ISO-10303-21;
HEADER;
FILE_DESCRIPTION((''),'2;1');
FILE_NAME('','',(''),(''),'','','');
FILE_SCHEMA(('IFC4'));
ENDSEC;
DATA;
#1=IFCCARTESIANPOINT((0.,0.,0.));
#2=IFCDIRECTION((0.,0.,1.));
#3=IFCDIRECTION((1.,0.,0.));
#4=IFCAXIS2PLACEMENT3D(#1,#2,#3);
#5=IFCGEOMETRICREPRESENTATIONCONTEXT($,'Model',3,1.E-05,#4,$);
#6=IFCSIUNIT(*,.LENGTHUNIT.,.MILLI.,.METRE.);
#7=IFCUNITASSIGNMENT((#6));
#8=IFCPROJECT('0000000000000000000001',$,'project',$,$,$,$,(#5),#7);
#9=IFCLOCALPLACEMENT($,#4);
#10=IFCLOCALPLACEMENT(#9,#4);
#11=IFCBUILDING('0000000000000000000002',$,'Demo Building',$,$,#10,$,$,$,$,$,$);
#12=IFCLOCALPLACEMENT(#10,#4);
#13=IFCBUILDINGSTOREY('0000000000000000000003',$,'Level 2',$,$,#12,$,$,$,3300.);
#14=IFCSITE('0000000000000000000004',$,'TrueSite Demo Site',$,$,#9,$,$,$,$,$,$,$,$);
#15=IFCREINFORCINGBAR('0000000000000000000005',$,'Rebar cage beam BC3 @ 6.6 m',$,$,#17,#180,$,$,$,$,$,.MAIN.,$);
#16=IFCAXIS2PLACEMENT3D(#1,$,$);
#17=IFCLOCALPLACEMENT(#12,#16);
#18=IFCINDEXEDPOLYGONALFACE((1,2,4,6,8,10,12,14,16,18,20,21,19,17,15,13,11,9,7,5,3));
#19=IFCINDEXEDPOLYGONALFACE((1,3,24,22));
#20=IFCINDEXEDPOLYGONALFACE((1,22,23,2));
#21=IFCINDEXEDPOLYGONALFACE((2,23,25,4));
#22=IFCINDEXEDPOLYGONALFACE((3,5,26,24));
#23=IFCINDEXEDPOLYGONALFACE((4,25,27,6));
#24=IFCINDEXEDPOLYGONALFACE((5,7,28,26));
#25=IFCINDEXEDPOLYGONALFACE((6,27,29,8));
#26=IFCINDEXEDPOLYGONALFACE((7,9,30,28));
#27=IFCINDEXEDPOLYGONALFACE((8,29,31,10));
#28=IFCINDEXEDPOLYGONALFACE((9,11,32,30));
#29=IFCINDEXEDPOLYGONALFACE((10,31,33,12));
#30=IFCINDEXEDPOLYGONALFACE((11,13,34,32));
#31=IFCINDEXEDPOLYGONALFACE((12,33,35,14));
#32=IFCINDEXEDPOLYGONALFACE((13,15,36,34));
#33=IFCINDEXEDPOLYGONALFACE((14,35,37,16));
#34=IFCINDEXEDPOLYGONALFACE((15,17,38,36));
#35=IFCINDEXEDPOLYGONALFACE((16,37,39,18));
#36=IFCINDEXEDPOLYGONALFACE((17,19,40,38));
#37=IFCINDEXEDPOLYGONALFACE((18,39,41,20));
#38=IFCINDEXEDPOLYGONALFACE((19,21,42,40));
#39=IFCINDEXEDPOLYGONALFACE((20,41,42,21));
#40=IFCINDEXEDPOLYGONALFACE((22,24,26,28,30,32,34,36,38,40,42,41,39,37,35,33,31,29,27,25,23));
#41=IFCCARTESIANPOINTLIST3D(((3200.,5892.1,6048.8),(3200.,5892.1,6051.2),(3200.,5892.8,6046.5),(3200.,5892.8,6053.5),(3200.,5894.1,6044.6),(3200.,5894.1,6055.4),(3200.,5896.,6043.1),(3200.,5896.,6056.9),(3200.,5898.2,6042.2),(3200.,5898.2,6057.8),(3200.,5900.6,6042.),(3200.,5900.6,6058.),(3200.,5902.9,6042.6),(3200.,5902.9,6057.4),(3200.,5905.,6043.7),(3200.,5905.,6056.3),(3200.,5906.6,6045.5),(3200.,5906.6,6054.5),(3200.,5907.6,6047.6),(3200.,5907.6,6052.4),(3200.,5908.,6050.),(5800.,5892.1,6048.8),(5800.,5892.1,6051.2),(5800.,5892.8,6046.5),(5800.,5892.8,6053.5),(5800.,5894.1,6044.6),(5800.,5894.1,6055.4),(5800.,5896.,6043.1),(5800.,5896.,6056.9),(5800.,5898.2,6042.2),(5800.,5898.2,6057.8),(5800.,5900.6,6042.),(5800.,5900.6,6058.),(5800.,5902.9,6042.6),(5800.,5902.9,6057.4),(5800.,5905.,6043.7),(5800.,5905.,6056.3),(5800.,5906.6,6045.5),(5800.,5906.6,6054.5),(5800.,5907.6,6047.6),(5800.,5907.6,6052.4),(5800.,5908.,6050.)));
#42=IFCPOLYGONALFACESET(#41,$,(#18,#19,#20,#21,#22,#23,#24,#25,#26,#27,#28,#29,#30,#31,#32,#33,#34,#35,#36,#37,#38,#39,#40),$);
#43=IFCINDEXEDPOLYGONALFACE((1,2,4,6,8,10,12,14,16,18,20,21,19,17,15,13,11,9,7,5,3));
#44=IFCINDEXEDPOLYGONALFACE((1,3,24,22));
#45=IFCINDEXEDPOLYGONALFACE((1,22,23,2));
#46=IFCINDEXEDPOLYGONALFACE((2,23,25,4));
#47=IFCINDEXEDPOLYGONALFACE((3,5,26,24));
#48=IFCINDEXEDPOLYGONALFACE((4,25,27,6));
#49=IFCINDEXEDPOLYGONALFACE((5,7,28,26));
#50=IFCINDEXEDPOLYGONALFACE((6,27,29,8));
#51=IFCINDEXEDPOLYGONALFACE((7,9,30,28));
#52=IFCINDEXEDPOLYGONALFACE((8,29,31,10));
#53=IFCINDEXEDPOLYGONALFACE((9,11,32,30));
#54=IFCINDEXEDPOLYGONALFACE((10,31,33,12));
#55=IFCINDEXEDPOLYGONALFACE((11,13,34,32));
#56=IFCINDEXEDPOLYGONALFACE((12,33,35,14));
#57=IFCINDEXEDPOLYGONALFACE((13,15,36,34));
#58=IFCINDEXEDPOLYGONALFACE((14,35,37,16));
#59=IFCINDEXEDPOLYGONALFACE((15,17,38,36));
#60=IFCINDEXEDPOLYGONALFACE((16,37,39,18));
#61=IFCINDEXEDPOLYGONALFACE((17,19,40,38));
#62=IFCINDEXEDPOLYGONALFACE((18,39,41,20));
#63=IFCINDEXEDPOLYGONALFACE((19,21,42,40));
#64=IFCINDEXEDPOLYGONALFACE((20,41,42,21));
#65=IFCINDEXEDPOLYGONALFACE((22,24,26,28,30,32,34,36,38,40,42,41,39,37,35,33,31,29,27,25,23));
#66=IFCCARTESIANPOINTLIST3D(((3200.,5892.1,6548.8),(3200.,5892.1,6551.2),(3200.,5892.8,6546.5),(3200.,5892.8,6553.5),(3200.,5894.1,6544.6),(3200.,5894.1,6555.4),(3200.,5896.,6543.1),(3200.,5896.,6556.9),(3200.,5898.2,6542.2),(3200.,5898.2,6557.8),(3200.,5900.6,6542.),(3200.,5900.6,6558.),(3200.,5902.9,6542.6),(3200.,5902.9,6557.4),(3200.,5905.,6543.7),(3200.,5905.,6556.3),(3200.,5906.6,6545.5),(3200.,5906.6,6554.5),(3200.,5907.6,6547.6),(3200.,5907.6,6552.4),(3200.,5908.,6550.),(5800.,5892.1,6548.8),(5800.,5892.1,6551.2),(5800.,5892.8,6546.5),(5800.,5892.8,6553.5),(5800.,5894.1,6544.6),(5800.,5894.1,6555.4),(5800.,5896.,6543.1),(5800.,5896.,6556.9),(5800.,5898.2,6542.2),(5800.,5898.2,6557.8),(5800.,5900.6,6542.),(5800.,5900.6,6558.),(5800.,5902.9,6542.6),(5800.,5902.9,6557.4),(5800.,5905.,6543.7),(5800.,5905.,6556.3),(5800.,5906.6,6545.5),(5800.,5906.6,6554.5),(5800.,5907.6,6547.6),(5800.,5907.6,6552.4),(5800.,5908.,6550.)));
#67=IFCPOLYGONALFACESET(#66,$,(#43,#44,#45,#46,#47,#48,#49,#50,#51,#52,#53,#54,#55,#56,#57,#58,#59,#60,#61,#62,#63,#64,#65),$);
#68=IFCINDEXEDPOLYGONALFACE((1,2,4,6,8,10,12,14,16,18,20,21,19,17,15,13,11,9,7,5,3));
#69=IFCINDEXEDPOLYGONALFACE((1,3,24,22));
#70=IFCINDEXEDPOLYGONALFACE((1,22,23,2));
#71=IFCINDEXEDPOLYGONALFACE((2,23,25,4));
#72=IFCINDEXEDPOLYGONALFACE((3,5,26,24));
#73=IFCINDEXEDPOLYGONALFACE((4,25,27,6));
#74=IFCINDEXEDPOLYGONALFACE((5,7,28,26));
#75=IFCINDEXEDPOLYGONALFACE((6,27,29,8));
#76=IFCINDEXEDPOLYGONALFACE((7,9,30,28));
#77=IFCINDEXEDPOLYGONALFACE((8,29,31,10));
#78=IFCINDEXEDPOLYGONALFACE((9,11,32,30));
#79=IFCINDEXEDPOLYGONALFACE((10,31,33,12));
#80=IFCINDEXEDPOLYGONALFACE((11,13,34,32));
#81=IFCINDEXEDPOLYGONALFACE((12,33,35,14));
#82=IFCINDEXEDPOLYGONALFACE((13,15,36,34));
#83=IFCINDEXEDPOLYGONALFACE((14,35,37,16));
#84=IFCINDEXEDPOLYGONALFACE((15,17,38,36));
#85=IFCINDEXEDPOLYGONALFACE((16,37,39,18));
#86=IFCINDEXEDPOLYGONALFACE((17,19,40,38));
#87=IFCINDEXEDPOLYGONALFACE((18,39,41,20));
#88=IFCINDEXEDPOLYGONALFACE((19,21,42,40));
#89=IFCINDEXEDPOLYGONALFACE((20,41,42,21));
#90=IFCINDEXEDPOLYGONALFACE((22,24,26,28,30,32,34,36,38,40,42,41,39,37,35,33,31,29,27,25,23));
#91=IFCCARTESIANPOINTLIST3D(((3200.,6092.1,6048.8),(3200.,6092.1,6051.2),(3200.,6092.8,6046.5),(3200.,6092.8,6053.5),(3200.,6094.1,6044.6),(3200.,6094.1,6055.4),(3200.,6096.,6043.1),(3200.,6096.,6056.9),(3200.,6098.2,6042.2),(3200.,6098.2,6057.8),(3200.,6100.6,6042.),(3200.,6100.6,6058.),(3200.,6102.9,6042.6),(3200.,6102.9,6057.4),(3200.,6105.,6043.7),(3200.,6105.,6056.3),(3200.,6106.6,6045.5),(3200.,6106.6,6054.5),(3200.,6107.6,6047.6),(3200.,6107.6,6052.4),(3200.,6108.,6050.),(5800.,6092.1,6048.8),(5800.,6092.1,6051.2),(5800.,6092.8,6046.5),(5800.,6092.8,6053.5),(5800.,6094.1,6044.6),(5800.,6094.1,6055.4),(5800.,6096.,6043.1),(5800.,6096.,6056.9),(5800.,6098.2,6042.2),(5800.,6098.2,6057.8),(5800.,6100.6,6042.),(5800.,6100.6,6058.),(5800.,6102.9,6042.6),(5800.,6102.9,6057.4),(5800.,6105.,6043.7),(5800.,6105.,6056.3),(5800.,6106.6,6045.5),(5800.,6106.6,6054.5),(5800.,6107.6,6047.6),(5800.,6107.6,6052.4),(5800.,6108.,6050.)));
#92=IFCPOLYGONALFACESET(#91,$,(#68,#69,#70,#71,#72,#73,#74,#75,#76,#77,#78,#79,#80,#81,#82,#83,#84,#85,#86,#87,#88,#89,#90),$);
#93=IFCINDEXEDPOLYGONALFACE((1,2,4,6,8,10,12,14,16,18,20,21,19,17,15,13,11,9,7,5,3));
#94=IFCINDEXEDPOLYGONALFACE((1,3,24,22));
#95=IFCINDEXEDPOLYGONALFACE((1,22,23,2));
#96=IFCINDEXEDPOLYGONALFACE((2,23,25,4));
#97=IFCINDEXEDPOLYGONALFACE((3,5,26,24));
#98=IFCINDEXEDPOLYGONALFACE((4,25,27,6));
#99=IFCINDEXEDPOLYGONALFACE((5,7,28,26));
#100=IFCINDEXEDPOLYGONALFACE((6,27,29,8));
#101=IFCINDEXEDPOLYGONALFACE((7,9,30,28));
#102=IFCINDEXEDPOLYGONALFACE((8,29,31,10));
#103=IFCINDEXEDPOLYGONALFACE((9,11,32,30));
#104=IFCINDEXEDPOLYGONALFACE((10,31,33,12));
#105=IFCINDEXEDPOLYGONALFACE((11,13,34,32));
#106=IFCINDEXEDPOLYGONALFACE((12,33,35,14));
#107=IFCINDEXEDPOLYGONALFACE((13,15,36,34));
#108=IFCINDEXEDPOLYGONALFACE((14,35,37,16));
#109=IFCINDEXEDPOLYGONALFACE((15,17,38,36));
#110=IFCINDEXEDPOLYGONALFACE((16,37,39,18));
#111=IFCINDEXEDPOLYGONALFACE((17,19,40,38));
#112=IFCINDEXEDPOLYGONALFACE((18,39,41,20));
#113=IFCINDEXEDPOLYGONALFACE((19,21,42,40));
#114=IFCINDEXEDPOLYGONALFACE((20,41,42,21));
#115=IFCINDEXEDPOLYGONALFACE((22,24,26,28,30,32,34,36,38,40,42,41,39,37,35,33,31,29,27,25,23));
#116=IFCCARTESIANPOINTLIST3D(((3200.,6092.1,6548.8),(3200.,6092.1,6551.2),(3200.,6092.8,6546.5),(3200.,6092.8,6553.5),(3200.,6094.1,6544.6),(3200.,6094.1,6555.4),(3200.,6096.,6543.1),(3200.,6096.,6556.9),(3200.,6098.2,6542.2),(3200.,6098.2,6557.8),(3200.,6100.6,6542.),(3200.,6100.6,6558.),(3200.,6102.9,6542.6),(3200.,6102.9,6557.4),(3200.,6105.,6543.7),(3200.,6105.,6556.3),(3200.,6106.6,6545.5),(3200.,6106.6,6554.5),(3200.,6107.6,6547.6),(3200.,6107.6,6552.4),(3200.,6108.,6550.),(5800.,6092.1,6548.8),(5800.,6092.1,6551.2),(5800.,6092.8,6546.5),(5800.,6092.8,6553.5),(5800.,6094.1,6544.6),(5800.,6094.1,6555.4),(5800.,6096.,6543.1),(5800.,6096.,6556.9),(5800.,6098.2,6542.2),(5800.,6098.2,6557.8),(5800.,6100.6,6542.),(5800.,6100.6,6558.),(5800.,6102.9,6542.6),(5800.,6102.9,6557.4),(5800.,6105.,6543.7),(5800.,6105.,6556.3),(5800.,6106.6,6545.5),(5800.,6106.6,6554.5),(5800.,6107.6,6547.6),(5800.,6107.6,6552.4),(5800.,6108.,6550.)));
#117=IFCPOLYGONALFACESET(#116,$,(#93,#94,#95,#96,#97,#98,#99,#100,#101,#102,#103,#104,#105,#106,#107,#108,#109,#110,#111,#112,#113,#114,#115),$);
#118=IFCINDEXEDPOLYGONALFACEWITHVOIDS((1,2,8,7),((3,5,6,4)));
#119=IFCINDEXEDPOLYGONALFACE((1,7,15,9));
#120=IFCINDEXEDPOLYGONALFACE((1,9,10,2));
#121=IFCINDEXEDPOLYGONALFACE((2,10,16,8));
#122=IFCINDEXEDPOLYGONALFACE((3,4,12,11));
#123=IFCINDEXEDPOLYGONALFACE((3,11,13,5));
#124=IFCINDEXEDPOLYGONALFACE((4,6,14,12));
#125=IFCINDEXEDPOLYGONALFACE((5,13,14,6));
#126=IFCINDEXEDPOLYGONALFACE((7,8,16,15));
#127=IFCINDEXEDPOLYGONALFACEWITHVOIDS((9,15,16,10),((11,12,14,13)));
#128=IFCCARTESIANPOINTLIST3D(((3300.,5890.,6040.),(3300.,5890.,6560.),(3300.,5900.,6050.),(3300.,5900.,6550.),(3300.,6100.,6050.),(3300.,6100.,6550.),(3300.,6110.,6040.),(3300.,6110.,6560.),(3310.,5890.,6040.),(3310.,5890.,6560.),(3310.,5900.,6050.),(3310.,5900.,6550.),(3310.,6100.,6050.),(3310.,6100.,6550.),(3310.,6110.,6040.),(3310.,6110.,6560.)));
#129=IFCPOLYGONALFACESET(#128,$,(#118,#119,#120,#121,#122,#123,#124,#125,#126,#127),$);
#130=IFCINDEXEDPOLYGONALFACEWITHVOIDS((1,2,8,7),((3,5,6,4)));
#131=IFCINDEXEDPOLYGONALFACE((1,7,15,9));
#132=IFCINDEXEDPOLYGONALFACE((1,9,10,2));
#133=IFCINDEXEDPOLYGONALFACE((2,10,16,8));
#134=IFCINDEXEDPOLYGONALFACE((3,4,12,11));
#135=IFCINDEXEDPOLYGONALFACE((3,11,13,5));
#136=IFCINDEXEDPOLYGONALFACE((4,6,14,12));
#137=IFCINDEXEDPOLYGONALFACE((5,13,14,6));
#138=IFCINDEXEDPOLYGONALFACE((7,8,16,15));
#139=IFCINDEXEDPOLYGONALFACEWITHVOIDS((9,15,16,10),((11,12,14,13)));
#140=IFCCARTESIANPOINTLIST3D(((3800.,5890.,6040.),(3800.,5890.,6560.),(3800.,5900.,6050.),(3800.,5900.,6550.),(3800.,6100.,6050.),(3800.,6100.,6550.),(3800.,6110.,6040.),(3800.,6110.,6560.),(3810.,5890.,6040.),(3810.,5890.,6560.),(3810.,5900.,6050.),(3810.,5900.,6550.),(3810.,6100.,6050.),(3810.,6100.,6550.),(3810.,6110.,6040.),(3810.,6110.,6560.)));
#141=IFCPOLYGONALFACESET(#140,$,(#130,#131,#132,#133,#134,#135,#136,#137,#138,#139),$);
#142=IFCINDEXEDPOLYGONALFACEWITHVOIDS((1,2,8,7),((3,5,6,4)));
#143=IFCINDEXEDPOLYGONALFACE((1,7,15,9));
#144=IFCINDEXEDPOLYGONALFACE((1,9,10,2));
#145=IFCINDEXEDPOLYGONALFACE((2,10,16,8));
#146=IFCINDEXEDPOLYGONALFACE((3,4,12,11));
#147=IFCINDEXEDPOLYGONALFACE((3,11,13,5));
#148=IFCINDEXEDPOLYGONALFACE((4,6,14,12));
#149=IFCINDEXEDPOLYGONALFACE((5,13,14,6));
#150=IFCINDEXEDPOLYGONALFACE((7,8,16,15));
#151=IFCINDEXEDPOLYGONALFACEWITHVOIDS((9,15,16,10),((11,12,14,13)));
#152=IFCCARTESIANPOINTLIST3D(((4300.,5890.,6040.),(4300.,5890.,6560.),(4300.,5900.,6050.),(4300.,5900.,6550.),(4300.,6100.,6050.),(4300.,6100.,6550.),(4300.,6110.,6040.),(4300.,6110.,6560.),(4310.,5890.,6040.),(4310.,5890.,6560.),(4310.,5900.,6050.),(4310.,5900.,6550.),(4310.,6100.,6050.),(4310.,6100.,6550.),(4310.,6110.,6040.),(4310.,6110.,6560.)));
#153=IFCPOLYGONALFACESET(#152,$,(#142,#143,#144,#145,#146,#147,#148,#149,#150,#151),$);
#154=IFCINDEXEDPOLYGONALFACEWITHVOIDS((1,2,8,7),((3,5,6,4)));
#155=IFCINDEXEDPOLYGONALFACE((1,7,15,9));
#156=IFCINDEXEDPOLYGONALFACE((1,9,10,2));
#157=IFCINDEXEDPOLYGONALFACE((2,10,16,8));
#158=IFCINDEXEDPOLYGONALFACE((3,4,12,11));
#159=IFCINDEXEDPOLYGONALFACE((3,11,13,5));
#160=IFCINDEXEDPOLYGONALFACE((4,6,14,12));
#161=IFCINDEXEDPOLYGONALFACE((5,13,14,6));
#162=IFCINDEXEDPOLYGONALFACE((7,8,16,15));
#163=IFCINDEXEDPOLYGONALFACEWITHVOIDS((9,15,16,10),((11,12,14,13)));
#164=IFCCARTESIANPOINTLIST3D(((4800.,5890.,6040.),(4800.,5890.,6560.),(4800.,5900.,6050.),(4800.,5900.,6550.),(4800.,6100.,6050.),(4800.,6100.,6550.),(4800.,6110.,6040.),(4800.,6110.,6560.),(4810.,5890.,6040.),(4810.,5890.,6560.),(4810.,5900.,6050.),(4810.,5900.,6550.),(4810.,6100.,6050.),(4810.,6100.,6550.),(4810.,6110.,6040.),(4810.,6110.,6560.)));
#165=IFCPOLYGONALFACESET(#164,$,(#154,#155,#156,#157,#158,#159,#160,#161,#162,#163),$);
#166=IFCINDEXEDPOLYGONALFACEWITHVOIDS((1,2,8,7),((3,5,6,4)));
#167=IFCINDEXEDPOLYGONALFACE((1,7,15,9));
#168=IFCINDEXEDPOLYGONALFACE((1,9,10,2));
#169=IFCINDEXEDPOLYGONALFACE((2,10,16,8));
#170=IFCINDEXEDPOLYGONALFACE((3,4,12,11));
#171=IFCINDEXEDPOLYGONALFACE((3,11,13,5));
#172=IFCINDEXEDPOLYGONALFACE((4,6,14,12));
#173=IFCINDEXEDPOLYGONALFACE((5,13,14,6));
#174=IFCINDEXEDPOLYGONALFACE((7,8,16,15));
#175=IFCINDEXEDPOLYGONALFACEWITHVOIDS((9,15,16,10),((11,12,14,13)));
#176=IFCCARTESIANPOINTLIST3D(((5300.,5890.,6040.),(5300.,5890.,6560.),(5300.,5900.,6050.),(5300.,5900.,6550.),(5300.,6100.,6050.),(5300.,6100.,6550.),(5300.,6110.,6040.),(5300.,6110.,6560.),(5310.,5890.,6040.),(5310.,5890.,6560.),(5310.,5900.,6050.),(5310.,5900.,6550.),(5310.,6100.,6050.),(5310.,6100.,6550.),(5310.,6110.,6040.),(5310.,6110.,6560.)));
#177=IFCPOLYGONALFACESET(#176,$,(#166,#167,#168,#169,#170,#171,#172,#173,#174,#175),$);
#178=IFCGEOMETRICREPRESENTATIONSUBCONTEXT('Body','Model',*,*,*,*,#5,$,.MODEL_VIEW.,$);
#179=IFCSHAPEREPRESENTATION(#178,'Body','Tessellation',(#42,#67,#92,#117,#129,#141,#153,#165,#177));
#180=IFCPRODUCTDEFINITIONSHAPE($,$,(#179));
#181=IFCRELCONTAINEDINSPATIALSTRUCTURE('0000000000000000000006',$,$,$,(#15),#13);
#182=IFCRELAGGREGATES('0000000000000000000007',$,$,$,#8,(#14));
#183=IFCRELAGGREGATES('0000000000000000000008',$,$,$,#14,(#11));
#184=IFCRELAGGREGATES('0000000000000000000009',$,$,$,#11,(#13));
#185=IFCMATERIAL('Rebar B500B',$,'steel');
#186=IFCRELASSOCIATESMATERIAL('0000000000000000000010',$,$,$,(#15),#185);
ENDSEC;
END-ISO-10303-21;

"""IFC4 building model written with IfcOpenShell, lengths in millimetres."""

from ifc_helpers import new_model, si_unit, frame, origin_with_axes, place, context, subcontext, project, spatial, hollow_rectangle, circle, extrude, material, element, save


model = new_model("IFC4")

# Units and contexts
model_context = context("Model", 3, precision=1e-05, world=origin_with_axes())
body_context = subcontext(model_context, "Body", "Model", "MODEL_VIEW")
ifc_project = project(units=[si_unit("LENGTHUNIT", "METRE", prefix="MILLI")], contexts=[model_context])

# Site, building, storey
site_placement = place(None, origin_with_axes())
site = spatial("IfcSite", under=ifc_project, at=site_placement, Name="TrueSite Demo Site")
building_placement = place(site_placement, origin_with_axes())
building = spatial("IfcBuilding", under=site, at=building_placement, Name="Demo Building")
storey_placement = place(building_placement, origin_with_axes())
storey = spatial("IfcBuildingStorey", under=building, at=storey_placement, Name="Level 2", Elevation=3300.0)

# Reinforcing bar
ifc_material_1 = material(Name="Rebar B500B", Category="steel")
for number, where, z_axis, x_axis, name in (
    (1, (3200.0, 6000.0, 6300.0), (1.0, 0.0, 0.0), (0.0, 1.0, 0.0), "Rebar cage beam BC3 @ 6.6 m"),
):
    element("IfcReinforcingBar", number, at=place(storey_placement, frame(where, z_axis=z_axis, x_axis=x_axis)), inside=storey, material=ifc_material_1, Name=name, PredefinedType="MAIN", context=body_context, shape_type="SweptSolid", body=[
        extrude(circle(Radius=8.0), frame((-100.0, -250.0, 0.0)), (0.0, 0.0, 1.0), 2600.0),
        extrude(circle(Radius=8.0), frame((-100.0, 250.0, 0.0)), (0.0, 0.0, 1.0), 2600.0),
        extrude(circle(Radius=8.0), frame((100.0, -250.0, 0.0)), (0.0, 0.0, 1.0), 2600.0),
        extrude(circle(Radius=8.0), frame((100.0, 250.0, 0.0)), (0.0, 0.0, 1.0), 2600.0),
        extrude(hollow_rectangle(XDim=220.0, YDim=520.0, WallThickness=10.0), frame((0.0, 0.0, 100.0)), (0.0, 0.0, 1.0), 10.0),
        extrude(hollow_rectangle(XDim=220.0, YDim=520.0, WallThickness=10.0), frame((0.0, 0.0, 600.0)), (0.0, 0.0, 1.0), 10.0),
        extrude(hollow_rectangle(XDim=220.0, YDim=520.0, WallThickness=10.0), frame((0.0, 0.0, 1100.0)), (0.0, 0.0, 1.0), 10.0),
        extrude(hollow_rectangle(XDim=220.0, YDim=520.0, WallThickness=10.0), frame((0.0, 0.0, 1600.0)), (0.0, 0.0, 1.0), 10.0),
        extrude(hollow_rectangle(XDim=220.0, YDim=520.0, WallThickness=10.0), frame((0.0, 0.0, 2100.0)), (0.0, 0.0, 1.0), 10.0),
    ])

save(model, "model.ifc")
